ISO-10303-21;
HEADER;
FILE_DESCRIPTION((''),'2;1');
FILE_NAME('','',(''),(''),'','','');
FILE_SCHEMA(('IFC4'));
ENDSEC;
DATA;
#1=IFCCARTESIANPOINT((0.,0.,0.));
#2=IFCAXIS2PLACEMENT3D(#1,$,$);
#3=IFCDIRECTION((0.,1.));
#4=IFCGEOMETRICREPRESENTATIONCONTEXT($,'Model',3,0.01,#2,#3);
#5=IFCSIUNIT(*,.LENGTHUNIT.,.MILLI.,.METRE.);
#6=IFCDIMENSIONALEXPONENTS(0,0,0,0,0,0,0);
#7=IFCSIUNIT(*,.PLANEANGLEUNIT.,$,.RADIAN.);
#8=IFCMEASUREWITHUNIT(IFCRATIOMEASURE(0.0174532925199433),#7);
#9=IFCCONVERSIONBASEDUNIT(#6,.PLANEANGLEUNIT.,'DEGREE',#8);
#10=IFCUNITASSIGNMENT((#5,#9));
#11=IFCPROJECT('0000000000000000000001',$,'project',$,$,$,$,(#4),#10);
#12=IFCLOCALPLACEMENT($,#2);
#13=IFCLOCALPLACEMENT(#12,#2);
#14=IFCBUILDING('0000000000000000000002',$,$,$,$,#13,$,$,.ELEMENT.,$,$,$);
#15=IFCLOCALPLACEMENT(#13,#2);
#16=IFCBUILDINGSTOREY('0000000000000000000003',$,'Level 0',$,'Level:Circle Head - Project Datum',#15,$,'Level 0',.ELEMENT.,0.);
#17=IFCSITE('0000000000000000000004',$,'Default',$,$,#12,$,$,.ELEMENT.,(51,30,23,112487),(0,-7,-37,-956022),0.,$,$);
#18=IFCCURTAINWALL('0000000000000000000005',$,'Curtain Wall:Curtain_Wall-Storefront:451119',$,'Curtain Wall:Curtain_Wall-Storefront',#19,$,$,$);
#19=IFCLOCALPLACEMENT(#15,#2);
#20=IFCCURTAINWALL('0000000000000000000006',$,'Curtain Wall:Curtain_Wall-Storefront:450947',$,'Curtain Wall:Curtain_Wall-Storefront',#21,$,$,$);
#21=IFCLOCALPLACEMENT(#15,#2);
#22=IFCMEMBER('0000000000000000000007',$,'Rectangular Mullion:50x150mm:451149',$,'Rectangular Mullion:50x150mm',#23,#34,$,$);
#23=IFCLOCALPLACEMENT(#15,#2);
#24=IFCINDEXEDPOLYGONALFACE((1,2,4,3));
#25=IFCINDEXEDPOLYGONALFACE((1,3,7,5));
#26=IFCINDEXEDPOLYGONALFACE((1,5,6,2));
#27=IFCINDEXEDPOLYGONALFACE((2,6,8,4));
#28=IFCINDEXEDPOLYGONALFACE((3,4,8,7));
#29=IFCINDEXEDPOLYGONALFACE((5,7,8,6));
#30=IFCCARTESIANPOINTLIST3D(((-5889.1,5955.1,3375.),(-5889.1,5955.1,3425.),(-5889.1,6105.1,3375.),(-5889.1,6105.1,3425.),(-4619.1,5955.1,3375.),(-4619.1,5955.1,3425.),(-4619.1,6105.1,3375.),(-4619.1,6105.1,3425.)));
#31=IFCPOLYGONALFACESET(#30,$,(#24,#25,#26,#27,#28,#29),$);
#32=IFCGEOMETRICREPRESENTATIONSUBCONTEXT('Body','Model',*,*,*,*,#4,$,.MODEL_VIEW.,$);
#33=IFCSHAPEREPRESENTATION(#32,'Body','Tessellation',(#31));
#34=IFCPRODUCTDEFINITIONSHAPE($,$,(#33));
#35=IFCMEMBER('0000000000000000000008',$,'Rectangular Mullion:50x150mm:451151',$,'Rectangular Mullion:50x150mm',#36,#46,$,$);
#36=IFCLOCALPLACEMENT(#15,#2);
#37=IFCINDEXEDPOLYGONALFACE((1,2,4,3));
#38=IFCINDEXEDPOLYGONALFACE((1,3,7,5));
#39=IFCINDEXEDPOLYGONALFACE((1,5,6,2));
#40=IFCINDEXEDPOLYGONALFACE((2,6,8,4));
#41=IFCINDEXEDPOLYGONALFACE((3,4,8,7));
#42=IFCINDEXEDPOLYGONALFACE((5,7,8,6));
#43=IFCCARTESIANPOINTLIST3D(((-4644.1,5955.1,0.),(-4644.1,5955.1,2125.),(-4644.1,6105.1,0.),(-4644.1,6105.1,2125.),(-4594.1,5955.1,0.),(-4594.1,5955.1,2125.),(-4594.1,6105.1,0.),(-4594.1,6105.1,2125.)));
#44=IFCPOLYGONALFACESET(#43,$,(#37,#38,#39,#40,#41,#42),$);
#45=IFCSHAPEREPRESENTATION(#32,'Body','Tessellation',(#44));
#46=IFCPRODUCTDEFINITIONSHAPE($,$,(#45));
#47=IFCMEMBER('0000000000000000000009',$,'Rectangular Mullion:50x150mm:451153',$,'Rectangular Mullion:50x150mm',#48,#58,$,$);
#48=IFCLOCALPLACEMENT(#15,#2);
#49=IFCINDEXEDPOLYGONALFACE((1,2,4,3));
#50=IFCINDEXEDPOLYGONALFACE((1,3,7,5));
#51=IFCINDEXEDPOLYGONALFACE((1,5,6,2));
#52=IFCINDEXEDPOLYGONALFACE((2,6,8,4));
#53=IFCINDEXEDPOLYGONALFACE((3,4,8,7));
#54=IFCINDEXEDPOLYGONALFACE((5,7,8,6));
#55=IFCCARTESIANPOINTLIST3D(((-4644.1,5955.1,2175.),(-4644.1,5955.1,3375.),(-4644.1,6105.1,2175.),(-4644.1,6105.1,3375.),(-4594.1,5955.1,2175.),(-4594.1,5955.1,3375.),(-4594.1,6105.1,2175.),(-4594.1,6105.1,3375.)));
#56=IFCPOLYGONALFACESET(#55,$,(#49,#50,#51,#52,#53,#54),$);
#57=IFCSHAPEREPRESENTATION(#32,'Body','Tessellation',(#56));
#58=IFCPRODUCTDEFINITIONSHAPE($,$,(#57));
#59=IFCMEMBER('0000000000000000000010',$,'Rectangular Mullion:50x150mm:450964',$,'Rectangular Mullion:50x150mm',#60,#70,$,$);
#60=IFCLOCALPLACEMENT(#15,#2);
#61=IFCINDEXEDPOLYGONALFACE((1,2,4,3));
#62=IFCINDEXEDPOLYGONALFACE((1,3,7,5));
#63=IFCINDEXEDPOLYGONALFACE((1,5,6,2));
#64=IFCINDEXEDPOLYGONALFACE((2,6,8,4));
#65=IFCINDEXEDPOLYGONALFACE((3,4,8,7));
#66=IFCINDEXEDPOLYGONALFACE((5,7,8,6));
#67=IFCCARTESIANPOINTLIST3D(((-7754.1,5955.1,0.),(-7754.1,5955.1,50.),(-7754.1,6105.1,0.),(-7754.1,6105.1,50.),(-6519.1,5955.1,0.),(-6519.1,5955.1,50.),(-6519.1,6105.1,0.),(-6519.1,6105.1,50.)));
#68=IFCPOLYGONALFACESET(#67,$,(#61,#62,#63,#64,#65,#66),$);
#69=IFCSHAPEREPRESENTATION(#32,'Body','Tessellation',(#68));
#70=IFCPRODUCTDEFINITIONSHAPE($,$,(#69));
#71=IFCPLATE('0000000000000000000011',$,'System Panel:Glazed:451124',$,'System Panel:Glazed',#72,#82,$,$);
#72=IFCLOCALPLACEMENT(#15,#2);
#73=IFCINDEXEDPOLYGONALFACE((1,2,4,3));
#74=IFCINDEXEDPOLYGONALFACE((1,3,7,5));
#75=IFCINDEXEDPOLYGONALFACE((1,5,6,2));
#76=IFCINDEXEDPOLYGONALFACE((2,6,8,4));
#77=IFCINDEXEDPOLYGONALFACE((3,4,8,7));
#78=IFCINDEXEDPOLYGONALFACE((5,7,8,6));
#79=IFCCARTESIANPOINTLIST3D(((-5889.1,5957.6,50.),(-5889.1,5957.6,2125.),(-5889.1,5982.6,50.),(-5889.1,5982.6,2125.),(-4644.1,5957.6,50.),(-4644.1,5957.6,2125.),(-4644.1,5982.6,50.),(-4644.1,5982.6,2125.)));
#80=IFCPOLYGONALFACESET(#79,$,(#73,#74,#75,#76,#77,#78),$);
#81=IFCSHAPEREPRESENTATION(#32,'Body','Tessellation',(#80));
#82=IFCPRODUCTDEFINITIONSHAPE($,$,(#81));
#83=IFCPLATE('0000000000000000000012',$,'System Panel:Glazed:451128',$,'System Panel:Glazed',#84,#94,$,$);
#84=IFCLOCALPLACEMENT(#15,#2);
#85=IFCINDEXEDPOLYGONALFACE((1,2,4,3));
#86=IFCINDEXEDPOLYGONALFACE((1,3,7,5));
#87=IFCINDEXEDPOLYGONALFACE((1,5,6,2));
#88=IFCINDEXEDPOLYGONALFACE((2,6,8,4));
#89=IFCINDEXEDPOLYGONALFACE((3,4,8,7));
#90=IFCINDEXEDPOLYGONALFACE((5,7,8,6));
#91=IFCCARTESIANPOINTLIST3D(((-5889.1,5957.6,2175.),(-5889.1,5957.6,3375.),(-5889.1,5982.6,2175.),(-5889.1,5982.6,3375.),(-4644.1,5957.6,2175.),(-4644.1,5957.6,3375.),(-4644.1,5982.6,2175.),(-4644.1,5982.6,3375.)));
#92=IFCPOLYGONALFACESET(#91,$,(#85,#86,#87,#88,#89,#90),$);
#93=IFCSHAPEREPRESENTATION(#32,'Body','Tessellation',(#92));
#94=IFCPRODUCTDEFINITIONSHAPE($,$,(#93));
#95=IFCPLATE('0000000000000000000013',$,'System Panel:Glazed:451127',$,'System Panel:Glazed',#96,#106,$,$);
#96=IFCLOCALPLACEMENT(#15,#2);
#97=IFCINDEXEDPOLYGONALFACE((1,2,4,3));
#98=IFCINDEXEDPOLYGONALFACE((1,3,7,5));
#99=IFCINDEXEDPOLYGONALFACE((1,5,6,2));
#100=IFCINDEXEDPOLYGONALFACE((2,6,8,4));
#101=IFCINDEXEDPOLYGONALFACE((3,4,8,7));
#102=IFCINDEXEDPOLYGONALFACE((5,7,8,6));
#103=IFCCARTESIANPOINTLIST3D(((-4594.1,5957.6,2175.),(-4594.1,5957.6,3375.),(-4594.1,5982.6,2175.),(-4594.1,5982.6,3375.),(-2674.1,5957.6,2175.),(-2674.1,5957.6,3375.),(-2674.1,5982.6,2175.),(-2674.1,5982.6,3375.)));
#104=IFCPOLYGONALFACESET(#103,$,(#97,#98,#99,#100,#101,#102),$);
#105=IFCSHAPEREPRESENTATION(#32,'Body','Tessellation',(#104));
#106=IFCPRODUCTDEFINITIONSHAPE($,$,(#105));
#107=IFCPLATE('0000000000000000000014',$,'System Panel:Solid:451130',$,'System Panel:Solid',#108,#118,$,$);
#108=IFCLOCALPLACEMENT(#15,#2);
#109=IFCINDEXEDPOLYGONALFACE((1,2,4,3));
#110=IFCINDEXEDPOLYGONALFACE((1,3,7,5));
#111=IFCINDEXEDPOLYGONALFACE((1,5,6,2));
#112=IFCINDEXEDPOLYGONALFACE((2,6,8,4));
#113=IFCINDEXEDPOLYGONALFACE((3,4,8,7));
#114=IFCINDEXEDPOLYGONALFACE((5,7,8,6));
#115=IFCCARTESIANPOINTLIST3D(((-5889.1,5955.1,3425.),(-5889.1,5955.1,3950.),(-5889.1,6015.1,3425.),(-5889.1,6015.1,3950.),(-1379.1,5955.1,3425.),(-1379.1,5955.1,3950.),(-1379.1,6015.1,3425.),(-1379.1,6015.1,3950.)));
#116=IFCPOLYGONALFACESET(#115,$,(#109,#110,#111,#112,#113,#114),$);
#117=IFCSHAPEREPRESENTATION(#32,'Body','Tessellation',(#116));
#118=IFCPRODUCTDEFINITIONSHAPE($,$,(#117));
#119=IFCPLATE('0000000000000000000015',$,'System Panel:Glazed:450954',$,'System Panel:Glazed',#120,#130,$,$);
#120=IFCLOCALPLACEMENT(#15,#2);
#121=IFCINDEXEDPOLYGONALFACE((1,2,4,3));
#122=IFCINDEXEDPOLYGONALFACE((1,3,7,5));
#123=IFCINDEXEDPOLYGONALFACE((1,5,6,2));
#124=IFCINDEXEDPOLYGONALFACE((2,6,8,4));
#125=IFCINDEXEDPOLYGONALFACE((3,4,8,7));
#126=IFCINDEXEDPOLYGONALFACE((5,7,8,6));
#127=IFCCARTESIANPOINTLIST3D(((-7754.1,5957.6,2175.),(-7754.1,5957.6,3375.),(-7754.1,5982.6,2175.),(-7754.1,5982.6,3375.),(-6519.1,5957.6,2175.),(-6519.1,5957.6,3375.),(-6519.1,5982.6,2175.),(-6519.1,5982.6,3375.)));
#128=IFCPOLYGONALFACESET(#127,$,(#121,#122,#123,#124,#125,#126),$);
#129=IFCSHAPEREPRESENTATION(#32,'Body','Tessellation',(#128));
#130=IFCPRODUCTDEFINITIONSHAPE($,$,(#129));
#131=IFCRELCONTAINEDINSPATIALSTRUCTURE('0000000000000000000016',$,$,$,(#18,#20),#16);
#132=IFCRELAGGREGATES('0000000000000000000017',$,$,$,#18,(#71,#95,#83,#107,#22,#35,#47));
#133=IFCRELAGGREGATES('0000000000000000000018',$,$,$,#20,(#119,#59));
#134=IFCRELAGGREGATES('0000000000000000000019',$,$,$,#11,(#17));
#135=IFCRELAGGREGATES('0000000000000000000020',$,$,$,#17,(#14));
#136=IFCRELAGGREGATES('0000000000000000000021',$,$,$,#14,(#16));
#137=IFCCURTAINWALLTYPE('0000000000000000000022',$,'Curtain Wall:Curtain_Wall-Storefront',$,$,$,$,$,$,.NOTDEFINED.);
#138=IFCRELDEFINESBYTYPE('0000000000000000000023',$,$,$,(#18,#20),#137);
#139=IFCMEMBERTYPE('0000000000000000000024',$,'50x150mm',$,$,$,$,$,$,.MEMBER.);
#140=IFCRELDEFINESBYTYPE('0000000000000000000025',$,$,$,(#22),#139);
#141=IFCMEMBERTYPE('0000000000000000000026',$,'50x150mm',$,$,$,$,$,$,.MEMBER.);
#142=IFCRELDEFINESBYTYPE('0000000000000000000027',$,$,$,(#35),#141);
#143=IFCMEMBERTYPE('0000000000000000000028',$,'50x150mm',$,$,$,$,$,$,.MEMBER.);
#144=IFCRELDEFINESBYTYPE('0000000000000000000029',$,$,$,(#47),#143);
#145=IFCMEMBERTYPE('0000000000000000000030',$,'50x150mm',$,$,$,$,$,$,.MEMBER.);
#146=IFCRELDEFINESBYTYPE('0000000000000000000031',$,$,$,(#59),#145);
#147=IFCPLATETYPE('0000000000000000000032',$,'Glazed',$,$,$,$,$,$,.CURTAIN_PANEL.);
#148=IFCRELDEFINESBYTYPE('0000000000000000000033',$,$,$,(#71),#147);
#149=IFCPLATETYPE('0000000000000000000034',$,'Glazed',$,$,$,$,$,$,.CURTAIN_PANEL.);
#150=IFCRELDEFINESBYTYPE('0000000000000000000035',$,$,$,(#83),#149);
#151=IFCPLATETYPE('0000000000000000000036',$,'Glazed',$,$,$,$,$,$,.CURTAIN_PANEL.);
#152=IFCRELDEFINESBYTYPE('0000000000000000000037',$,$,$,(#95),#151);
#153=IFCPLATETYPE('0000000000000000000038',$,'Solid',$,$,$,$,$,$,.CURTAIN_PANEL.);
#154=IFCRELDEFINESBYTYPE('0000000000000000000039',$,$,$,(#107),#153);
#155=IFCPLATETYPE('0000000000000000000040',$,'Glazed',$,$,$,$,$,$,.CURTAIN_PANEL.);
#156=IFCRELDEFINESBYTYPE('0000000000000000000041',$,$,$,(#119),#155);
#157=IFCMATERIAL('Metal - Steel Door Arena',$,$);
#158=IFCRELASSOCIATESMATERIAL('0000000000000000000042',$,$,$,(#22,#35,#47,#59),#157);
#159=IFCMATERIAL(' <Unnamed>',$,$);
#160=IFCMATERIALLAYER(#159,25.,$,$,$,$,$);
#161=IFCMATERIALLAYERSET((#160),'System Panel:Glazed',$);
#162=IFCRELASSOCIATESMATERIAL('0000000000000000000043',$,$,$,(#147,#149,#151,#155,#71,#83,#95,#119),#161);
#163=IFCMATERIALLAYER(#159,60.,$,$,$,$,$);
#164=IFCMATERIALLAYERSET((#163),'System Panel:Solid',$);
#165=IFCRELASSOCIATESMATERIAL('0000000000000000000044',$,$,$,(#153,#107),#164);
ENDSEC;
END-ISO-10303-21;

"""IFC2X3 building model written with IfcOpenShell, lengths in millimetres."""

from ifc_helpers import new_model, entity, si_unit, converted_unit, direction, frame, frame_2d, origin, origin_2d_with_axis, place, context, subcontext, project, spatial, rectangle, extrude, source, transform, mapped, material, layer, layer_set, layer_usage, type_object, type_shapes, element, aggregate, save


model = new_model("IFC2X3")

# Units and contexts
model_context = context("Model", 3, precision=0.01, world=origin(), true_north=direction((0.0, 1.0)))
body_context = subcontext(model_context, "Body", "Model", "MODEL_VIEW")
ifc_project = project(units=[si_unit("LENGTHUNIT", "METRE", prefix="MILLI"), converted_unit("PLANEANGLEUNIT", "DEGREE", entity("IfcRatioMeasure", 0.0174532925199433), si_unit("PLANEANGLEUNIT", "RADIAN"), dimensions=[0, 0, 0, 0, 0, 0, 0])], contexts=[model_context])

# Site, building, storey
site_placement = place(None, origin())
site = spatial("IfcSite", under=ifc_project, at=site_placement, Name="Default", CompositionType="ELEMENT", RefLatitude=(51, 30, 23, 112487), RefLongitude=(0, -7, -37, -956022), RefElevation=0.0)
building_placement = place(site_placement, origin())
building = spatial("IfcBuilding", under=site, at=building_placement, CompositionType="ELEMENT")
storey_placement = place(building_placement, origin())
storey = spatial("IfcBuildingStorey", under=building, at=storey_placement, Name="Level 0", ObjectType="Level:Circle Head - Project Datum", LongName="Level 0", CompositionType="ELEMENT", Elevation=0.0)

# Curtain walls
curtain_wall_type = type_object("IfcCurtainWallType", Name="Curtain Wall:Curtain_Wall-Storefront", PredefinedType="NOTDEFINED")
curtain_wall_1_placement = place(storey_placement, origin())
curtain_wall_1 = element("IfcCurtainWall", 1, at=curtain_wall_1_placement, inside=storey, type_object=curtain_wall_type, Name="Curtain Wall:Curtain_Wall-Storefront:451119", ObjectType="Curtain Wall:Curtain_Wall-Storefront")
ifc_material_1 = material(Name="Metal - Steel Door Arena")
curtain_wall_2_placement = place(storey_placement, origin())
curtain_wall_2 = element("IfcCurtainWall", 2, at=curtain_wall_2_placement, inside=storey, type_object=curtain_wall_type, Name="Curtain Wall:Curtain_Wall-Storefront:450947", ObjectType="Curtain Wall:Curtain_Wall-Storefront")

# Members
member_type_1 = type_object("IfcMemberType", Name="50x150mm", PredefinedType="MEMBER")
shared_shape_1 = source(origin(), body_context, "Body", "SweptSolid", [
    extrude(rectangle(XDim=150.0, YDim=50.0, at=origin_2d_with_axis()), frame((0.0, 0.0, -1270.0), z_axis=(0.0, 0.0, 1.0), x_axis=(0.0, -1.0, 0.0)), (0.0, 0.0, 1.0), 1270.0),
])
type_shapes(member_type_1, [shared_shape_1])
member_1_placement = place(storey_placement, frame((-5889.1, 6030.1, 3400.0), z_axis=(-1.0, 0.0, 0.0), x_axis=(0.0, 0.0, 1.0)))
member_1 = element("IfcMember", 3, at=member_1_placement, type_object=member_type_1, material=ifc_material_1, Name="Rectangular Mullion:50x150mm:451149", ObjectType="Rectangular Mullion:50x150mm", context=body_context, shape_type="MappedRepresentation", body=[
    mapped(shared_shape_1, transform((0.0, 0.0, 0.0), scale=1.0)),
])
member_type_2 = type_object("IfcMemberType", Name="50x150mm", PredefinedType="MEMBER")
shared_shape_2 = source(origin(), body_context, "Body", "SweptSolid", [
    extrude(rectangle(XDim=150.0, YDim=50.0, at=origin_2d_with_axis()), frame((0.0, 0.0, -2125.0), z_axis=(0.0, 0.0, 1.0), x_axis=(0.0, -1.0, 0.0)), (0.0, 0.0, 1.0), 2125.0),
])
type_shapes(member_type_2, [shared_shape_2])
member_2_placement = place(storey_placement, frame((-4619.1, 6030.1, 0.0), z_axis=(0.0, 0.0, -1.0), x_axis=(-1.0, 0.0, 0.0)))
member_2 = element("IfcMember", 4, at=member_2_placement, type_object=member_type_2, material=ifc_material_1, Name="Rectangular Mullion:50x150mm:451151", ObjectType="Rectangular Mullion:50x150mm", context=body_context, shape_type="MappedRepresentation", body=[
    mapped(shared_shape_2, transform((0.0, 0.0, 0.0), scale=1.0)),
])
member_type_3 = type_object("IfcMemberType", Name="50x150mm", PredefinedType="MEMBER")
shared_shape_3 = source(origin(), body_context, "Body", "SweptSolid", [
    extrude(rectangle(XDim=150.0, YDim=50.0, at=origin_2d_with_axis()), frame((0.0, 0.0, -1200.0), z_axis=(0.0, 0.0, 1.0), x_axis=(0.0, -1.0, 0.0)), (0.0, 0.0, 1.0), 1200.0),
])
type_shapes(member_type_3, [shared_shape_3])
member_3_placement = place(storey_placement, frame((-4619.1, 6030.1, 2175.0), z_axis=(0.0, 0.0, -1.0), x_axis=(-1.0, 0.0, 0.0)))
member_3 = element("IfcMember", 5, at=member_3_placement, type_object=member_type_3, material=ifc_material_1, Name="Rectangular Mullion:50x150mm:451153", ObjectType="Rectangular Mullion:50x150mm", context=body_context, shape_type="MappedRepresentation", body=[
    mapped(shared_shape_3, transform((0.0, 0.0, 0.0), scale=1.0)),
])
member_type_4 = type_object("IfcMemberType", Name="50x150mm", PredefinedType="MEMBER")
shared_shape_4 = source(origin(), body_context, "Body", "SweptSolid", [
    extrude(rectangle(XDim=150.0, YDim=50.0, at=origin_2d_with_axis()), frame((-25.0, 0.0, -1235.0), z_axis=(0.0, 0.0, 1.0), x_axis=(0.0, -1.0, 0.0)), (0.0, 0.0, 1.0), 1235.0),
])
type_shapes(member_type_4, [shared_shape_4])
member_4_placement = place(storey_placement, frame((-6519.1, 6030.1, 0.0), z_axis=(1.0, 0.0, 0.0), x_axis=(0.0, 0.0, -1.0)))
member_4 = element("IfcMember", 6, at=member_4_placement, type_object=member_type_4, material=ifc_material_1, Name="Rectangular Mullion:50x150mm:450964", ObjectType="Rectangular Mullion:50x150mm", context=body_context, shape_type="MappedRepresentation", body=[
    mapped(shared_shape_4, transform((0.0, 0.0, 0.0), scale=1.0)),
])

# Plates
ifc_material_2 = material(Name=" <Unnamed>")
ifc_layer_1 = layer(ifc_material_2, 25.0)
ifc_layer_set_1 = layer_set([ifc_layer_1], Name="System Panel:Glazed")
ifc_layer_usage_1 = layer_usage(ifc_layer_set_1, "AXIS3", "POSITIVE", 0.2)
plate_type_1 = type_object("IfcPlateType", Name="Glazed", PredefinedType="CURTAIN_PANEL", material=ifc_layer_set_1)
shared_shape_5 = source(origin(), body_context, "Body", "SweptSolid", [
    extrude(rectangle(XDim=25.0, YDim=1245.0, at=origin_2d_with_axis()), frame((0.0, 60.0, 0.0), z_axis=(0.0, 0.0, 1.0), x_axis=(0.0, 1.0, 0.0)), (0.0, 0.0, 1.0), 2075.0),
])
type_shapes(plate_type_1, [shared_shape_5])
plate_1_placement = place(curtain_wall_1_placement, frame((-5266.6, 6030.1, 50.0), z_axis=(0.0, 0.0, 1.0), x_axis=(-1.0, 0.0, 0.0)))
plate_1 = element("IfcPlate", 7, at=plate_1_placement, type_object=plate_type_1, material=ifc_layer_usage_1, Name="System Panel:Glazed:451124", ObjectType="System Panel:Glazed", context=body_context, shape_type="MappedRepresentation", body=[
    mapped(shared_shape_5, transform((0.0, 0.0, 0.0), scale=1.0)),
])
ifc_layer_usage_2 = layer_usage(ifc_layer_set_1, "AXIS3", "POSITIVE", 0.2)
plate_type_2 = type_object("IfcPlateType", Name="Glazed", PredefinedType="CURTAIN_PANEL", material=ifc_layer_set_1)
shared_shape_6 = source(origin(), body_context, "Body", "SweptSolid", [
    extrude(rectangle(XDim=25.0, YDim=1245.0, at=origin_2d_with_axis()), frame((0.0, 60.0, 0.0), z_axis=(0.0, 0.0, 1.0), x_axis=(0.0, 1.0, 0.0)), (0.0, 0.0, 1.0), 1200.0),
])
type_shapes(plate_type_2, [shared_shape_6])
plate_2_placement = place(curtain_wall_1_placement, frame((-5266.6, 6030.1, 2175.0), z_axis=(0.0, 0.0, 1.0), x_axis=(-1.0, 0.0, 0.0)))
plate_2 = element("IfcPlate", 8, at=plate_2_placement, type_object=plate_type_2, material=ifc_layer_usage_2, Name="System Panel:Glazed:451128", ObjectType="System Panel:Glazed", context=body_context, shape_type="MappedRepresentation", body=[
    mapped(shared_shape_6, transform((0.0, 0.0, 0.0), scale=1.0)),
])
ifc_layer_usage_3 = layer_usage(ifc_layer_set_1, "AXIS3", "POSITIVE", 0.2)
plate_type_3 = type_object("IfcPlateType", Name="Glazed", PredefinedType="CURTAIN_PANEL", material=ifc_layer_set_1)
shared_shape_7 = source(origin(), body_context, "Body", "SweptSolid", [
    extrude(rectangle(XDim=25.0, YDim=1920.0, at=origin_2d_with_axis()), frame((0.0, 60.0, 0.0), z_axis=(0.0, 0.0, 1.0), x_axis=(0.0, 1.0, 0.0)), (0.0, 0.0, 1.0), 1200.0),
])
type_shapes(plate_type_3, [shared_shape_7])
plate_3_placement = place(curtain_wall_1_placement, frame((-3634.1, 6030.1, 2175.0), z_axis=(0.0, 0.0, 1.0), x_axis=(-1.0, 0.0, 0.0)))
plate_3 = element("IfcPlate", 9, at=plate_3_placement, type_object=plate_type_3, material=ifc_layer_usage_3, Name="System Panel:Glazed:451127", ObjectType="System Panel:Glazed", context=body_context, shape_type="MappedRepresentation", body=[
    mapped(shared_shape_7, transform((0.0, 0.0, 0.0), scale=1.0)),
])
ifc_layer_2 = layer(ifc_material_2, 60.0)
ifc_layer_set_2 = layer_set([ifc_layer_2], Name="System Panel:Solid")
ifc_layer_usage_4 = layer_usage(ifc_layer_set_2, "AXIS3", "POSITIVE", 0.1)
plate_type_4 = type_object("IfcPlateType", Name="Solid", PredefinedType="CURTAIN_PANEL", material=ifc_layer_set_2)
shared_shape_8 = source(origin(), body_context, "Body", "SweptSolid", [
    extrude(rectangle(XDim=525.0, YDim=4510.0, at=frame_2d((0.0, 0.0), x_axis=(1.0, 0.0))), frame((0.0, 15.0, 262.5), z_axis=(0.0, 1.0, 0.0), x_axis=(0.0, 0.0, 1.0)), (0.0, 0.0, 1.0), 60.0),
])
type_shapes(plate_type_4, [shared_shape_8])
plate_4_placement = place(curtain_wall_1_placement, frame((-3634.1, 6030.1, 3425.0), z_axis=(0.0, 0.0, 1.0), x_axis=(-1.0, 0.0, 0.0)))
plate_4 = element("IfcPlate", 10, at=plate_4_placement, type_object=plate_type_4, material=ifc_layer_usage_4, Name="System Panel:Solid:451130", ObjectType="System Panel:Solid", context=body_context, shape_type="MappedRepresentation", body=[
    mapped(shared_shape_8, transform((0.0, 0.0, 0.0), scale=1.0)),
])
aggregate(curtain_wall_1, [plate_1, plate_3, plate_2, plate_4, member_1, member_2, member_3])
ifc_layer_usage_5 = layer_usage(ifc_layer_set_1, "AXIS3", "POSITIVE", 0.2)
plate_type_5 = type_object("IfcPlateType", Name="Glazed", PredefinedType="CURTAIN_PANEL", material=ifc_layer_set_1)
shared_shape_9 = source(origin(), body_context, "Body", "SweptSolid", [
    extrude(rectangle(XDim=25.0, YDim=1235.0, at=origin_2d_with_axis()), frame((0.0, 60.0, 0.0), z_axis=(0.0, 0.0, 1.0), x_axis=(0.0, 1.0, 0.0)), (0.0, 0.0, 1.0), 1200.0),
])
type_shapes(plate_type_5, [shared_shape_9])
plate_5_placement = place(curtain_wall_2_placement, frame((-7136.6, 6030.1, 2175.0), z_axis=(0.0, 0.0, 1.0), x_axis=(-1.0, 0.0, 0.0)))
plate_5 = element("IfcPlate", 11, at=plate_5_placement, type_object=plate_type_5, material=ifc_layer_usage_5, Name="System Panel:Glazed:450954", ObjectType="System Panel:Glazed", context=body_context, shape_type="MappedRepresentation", body=[
    mapped(shared_shape_9, transform((0.0, 0.0, 0.0), scale=1.0)),
])
aggregate(curtain_wall_2, [plate_5, member_4])

save(model, "model.ifc")
